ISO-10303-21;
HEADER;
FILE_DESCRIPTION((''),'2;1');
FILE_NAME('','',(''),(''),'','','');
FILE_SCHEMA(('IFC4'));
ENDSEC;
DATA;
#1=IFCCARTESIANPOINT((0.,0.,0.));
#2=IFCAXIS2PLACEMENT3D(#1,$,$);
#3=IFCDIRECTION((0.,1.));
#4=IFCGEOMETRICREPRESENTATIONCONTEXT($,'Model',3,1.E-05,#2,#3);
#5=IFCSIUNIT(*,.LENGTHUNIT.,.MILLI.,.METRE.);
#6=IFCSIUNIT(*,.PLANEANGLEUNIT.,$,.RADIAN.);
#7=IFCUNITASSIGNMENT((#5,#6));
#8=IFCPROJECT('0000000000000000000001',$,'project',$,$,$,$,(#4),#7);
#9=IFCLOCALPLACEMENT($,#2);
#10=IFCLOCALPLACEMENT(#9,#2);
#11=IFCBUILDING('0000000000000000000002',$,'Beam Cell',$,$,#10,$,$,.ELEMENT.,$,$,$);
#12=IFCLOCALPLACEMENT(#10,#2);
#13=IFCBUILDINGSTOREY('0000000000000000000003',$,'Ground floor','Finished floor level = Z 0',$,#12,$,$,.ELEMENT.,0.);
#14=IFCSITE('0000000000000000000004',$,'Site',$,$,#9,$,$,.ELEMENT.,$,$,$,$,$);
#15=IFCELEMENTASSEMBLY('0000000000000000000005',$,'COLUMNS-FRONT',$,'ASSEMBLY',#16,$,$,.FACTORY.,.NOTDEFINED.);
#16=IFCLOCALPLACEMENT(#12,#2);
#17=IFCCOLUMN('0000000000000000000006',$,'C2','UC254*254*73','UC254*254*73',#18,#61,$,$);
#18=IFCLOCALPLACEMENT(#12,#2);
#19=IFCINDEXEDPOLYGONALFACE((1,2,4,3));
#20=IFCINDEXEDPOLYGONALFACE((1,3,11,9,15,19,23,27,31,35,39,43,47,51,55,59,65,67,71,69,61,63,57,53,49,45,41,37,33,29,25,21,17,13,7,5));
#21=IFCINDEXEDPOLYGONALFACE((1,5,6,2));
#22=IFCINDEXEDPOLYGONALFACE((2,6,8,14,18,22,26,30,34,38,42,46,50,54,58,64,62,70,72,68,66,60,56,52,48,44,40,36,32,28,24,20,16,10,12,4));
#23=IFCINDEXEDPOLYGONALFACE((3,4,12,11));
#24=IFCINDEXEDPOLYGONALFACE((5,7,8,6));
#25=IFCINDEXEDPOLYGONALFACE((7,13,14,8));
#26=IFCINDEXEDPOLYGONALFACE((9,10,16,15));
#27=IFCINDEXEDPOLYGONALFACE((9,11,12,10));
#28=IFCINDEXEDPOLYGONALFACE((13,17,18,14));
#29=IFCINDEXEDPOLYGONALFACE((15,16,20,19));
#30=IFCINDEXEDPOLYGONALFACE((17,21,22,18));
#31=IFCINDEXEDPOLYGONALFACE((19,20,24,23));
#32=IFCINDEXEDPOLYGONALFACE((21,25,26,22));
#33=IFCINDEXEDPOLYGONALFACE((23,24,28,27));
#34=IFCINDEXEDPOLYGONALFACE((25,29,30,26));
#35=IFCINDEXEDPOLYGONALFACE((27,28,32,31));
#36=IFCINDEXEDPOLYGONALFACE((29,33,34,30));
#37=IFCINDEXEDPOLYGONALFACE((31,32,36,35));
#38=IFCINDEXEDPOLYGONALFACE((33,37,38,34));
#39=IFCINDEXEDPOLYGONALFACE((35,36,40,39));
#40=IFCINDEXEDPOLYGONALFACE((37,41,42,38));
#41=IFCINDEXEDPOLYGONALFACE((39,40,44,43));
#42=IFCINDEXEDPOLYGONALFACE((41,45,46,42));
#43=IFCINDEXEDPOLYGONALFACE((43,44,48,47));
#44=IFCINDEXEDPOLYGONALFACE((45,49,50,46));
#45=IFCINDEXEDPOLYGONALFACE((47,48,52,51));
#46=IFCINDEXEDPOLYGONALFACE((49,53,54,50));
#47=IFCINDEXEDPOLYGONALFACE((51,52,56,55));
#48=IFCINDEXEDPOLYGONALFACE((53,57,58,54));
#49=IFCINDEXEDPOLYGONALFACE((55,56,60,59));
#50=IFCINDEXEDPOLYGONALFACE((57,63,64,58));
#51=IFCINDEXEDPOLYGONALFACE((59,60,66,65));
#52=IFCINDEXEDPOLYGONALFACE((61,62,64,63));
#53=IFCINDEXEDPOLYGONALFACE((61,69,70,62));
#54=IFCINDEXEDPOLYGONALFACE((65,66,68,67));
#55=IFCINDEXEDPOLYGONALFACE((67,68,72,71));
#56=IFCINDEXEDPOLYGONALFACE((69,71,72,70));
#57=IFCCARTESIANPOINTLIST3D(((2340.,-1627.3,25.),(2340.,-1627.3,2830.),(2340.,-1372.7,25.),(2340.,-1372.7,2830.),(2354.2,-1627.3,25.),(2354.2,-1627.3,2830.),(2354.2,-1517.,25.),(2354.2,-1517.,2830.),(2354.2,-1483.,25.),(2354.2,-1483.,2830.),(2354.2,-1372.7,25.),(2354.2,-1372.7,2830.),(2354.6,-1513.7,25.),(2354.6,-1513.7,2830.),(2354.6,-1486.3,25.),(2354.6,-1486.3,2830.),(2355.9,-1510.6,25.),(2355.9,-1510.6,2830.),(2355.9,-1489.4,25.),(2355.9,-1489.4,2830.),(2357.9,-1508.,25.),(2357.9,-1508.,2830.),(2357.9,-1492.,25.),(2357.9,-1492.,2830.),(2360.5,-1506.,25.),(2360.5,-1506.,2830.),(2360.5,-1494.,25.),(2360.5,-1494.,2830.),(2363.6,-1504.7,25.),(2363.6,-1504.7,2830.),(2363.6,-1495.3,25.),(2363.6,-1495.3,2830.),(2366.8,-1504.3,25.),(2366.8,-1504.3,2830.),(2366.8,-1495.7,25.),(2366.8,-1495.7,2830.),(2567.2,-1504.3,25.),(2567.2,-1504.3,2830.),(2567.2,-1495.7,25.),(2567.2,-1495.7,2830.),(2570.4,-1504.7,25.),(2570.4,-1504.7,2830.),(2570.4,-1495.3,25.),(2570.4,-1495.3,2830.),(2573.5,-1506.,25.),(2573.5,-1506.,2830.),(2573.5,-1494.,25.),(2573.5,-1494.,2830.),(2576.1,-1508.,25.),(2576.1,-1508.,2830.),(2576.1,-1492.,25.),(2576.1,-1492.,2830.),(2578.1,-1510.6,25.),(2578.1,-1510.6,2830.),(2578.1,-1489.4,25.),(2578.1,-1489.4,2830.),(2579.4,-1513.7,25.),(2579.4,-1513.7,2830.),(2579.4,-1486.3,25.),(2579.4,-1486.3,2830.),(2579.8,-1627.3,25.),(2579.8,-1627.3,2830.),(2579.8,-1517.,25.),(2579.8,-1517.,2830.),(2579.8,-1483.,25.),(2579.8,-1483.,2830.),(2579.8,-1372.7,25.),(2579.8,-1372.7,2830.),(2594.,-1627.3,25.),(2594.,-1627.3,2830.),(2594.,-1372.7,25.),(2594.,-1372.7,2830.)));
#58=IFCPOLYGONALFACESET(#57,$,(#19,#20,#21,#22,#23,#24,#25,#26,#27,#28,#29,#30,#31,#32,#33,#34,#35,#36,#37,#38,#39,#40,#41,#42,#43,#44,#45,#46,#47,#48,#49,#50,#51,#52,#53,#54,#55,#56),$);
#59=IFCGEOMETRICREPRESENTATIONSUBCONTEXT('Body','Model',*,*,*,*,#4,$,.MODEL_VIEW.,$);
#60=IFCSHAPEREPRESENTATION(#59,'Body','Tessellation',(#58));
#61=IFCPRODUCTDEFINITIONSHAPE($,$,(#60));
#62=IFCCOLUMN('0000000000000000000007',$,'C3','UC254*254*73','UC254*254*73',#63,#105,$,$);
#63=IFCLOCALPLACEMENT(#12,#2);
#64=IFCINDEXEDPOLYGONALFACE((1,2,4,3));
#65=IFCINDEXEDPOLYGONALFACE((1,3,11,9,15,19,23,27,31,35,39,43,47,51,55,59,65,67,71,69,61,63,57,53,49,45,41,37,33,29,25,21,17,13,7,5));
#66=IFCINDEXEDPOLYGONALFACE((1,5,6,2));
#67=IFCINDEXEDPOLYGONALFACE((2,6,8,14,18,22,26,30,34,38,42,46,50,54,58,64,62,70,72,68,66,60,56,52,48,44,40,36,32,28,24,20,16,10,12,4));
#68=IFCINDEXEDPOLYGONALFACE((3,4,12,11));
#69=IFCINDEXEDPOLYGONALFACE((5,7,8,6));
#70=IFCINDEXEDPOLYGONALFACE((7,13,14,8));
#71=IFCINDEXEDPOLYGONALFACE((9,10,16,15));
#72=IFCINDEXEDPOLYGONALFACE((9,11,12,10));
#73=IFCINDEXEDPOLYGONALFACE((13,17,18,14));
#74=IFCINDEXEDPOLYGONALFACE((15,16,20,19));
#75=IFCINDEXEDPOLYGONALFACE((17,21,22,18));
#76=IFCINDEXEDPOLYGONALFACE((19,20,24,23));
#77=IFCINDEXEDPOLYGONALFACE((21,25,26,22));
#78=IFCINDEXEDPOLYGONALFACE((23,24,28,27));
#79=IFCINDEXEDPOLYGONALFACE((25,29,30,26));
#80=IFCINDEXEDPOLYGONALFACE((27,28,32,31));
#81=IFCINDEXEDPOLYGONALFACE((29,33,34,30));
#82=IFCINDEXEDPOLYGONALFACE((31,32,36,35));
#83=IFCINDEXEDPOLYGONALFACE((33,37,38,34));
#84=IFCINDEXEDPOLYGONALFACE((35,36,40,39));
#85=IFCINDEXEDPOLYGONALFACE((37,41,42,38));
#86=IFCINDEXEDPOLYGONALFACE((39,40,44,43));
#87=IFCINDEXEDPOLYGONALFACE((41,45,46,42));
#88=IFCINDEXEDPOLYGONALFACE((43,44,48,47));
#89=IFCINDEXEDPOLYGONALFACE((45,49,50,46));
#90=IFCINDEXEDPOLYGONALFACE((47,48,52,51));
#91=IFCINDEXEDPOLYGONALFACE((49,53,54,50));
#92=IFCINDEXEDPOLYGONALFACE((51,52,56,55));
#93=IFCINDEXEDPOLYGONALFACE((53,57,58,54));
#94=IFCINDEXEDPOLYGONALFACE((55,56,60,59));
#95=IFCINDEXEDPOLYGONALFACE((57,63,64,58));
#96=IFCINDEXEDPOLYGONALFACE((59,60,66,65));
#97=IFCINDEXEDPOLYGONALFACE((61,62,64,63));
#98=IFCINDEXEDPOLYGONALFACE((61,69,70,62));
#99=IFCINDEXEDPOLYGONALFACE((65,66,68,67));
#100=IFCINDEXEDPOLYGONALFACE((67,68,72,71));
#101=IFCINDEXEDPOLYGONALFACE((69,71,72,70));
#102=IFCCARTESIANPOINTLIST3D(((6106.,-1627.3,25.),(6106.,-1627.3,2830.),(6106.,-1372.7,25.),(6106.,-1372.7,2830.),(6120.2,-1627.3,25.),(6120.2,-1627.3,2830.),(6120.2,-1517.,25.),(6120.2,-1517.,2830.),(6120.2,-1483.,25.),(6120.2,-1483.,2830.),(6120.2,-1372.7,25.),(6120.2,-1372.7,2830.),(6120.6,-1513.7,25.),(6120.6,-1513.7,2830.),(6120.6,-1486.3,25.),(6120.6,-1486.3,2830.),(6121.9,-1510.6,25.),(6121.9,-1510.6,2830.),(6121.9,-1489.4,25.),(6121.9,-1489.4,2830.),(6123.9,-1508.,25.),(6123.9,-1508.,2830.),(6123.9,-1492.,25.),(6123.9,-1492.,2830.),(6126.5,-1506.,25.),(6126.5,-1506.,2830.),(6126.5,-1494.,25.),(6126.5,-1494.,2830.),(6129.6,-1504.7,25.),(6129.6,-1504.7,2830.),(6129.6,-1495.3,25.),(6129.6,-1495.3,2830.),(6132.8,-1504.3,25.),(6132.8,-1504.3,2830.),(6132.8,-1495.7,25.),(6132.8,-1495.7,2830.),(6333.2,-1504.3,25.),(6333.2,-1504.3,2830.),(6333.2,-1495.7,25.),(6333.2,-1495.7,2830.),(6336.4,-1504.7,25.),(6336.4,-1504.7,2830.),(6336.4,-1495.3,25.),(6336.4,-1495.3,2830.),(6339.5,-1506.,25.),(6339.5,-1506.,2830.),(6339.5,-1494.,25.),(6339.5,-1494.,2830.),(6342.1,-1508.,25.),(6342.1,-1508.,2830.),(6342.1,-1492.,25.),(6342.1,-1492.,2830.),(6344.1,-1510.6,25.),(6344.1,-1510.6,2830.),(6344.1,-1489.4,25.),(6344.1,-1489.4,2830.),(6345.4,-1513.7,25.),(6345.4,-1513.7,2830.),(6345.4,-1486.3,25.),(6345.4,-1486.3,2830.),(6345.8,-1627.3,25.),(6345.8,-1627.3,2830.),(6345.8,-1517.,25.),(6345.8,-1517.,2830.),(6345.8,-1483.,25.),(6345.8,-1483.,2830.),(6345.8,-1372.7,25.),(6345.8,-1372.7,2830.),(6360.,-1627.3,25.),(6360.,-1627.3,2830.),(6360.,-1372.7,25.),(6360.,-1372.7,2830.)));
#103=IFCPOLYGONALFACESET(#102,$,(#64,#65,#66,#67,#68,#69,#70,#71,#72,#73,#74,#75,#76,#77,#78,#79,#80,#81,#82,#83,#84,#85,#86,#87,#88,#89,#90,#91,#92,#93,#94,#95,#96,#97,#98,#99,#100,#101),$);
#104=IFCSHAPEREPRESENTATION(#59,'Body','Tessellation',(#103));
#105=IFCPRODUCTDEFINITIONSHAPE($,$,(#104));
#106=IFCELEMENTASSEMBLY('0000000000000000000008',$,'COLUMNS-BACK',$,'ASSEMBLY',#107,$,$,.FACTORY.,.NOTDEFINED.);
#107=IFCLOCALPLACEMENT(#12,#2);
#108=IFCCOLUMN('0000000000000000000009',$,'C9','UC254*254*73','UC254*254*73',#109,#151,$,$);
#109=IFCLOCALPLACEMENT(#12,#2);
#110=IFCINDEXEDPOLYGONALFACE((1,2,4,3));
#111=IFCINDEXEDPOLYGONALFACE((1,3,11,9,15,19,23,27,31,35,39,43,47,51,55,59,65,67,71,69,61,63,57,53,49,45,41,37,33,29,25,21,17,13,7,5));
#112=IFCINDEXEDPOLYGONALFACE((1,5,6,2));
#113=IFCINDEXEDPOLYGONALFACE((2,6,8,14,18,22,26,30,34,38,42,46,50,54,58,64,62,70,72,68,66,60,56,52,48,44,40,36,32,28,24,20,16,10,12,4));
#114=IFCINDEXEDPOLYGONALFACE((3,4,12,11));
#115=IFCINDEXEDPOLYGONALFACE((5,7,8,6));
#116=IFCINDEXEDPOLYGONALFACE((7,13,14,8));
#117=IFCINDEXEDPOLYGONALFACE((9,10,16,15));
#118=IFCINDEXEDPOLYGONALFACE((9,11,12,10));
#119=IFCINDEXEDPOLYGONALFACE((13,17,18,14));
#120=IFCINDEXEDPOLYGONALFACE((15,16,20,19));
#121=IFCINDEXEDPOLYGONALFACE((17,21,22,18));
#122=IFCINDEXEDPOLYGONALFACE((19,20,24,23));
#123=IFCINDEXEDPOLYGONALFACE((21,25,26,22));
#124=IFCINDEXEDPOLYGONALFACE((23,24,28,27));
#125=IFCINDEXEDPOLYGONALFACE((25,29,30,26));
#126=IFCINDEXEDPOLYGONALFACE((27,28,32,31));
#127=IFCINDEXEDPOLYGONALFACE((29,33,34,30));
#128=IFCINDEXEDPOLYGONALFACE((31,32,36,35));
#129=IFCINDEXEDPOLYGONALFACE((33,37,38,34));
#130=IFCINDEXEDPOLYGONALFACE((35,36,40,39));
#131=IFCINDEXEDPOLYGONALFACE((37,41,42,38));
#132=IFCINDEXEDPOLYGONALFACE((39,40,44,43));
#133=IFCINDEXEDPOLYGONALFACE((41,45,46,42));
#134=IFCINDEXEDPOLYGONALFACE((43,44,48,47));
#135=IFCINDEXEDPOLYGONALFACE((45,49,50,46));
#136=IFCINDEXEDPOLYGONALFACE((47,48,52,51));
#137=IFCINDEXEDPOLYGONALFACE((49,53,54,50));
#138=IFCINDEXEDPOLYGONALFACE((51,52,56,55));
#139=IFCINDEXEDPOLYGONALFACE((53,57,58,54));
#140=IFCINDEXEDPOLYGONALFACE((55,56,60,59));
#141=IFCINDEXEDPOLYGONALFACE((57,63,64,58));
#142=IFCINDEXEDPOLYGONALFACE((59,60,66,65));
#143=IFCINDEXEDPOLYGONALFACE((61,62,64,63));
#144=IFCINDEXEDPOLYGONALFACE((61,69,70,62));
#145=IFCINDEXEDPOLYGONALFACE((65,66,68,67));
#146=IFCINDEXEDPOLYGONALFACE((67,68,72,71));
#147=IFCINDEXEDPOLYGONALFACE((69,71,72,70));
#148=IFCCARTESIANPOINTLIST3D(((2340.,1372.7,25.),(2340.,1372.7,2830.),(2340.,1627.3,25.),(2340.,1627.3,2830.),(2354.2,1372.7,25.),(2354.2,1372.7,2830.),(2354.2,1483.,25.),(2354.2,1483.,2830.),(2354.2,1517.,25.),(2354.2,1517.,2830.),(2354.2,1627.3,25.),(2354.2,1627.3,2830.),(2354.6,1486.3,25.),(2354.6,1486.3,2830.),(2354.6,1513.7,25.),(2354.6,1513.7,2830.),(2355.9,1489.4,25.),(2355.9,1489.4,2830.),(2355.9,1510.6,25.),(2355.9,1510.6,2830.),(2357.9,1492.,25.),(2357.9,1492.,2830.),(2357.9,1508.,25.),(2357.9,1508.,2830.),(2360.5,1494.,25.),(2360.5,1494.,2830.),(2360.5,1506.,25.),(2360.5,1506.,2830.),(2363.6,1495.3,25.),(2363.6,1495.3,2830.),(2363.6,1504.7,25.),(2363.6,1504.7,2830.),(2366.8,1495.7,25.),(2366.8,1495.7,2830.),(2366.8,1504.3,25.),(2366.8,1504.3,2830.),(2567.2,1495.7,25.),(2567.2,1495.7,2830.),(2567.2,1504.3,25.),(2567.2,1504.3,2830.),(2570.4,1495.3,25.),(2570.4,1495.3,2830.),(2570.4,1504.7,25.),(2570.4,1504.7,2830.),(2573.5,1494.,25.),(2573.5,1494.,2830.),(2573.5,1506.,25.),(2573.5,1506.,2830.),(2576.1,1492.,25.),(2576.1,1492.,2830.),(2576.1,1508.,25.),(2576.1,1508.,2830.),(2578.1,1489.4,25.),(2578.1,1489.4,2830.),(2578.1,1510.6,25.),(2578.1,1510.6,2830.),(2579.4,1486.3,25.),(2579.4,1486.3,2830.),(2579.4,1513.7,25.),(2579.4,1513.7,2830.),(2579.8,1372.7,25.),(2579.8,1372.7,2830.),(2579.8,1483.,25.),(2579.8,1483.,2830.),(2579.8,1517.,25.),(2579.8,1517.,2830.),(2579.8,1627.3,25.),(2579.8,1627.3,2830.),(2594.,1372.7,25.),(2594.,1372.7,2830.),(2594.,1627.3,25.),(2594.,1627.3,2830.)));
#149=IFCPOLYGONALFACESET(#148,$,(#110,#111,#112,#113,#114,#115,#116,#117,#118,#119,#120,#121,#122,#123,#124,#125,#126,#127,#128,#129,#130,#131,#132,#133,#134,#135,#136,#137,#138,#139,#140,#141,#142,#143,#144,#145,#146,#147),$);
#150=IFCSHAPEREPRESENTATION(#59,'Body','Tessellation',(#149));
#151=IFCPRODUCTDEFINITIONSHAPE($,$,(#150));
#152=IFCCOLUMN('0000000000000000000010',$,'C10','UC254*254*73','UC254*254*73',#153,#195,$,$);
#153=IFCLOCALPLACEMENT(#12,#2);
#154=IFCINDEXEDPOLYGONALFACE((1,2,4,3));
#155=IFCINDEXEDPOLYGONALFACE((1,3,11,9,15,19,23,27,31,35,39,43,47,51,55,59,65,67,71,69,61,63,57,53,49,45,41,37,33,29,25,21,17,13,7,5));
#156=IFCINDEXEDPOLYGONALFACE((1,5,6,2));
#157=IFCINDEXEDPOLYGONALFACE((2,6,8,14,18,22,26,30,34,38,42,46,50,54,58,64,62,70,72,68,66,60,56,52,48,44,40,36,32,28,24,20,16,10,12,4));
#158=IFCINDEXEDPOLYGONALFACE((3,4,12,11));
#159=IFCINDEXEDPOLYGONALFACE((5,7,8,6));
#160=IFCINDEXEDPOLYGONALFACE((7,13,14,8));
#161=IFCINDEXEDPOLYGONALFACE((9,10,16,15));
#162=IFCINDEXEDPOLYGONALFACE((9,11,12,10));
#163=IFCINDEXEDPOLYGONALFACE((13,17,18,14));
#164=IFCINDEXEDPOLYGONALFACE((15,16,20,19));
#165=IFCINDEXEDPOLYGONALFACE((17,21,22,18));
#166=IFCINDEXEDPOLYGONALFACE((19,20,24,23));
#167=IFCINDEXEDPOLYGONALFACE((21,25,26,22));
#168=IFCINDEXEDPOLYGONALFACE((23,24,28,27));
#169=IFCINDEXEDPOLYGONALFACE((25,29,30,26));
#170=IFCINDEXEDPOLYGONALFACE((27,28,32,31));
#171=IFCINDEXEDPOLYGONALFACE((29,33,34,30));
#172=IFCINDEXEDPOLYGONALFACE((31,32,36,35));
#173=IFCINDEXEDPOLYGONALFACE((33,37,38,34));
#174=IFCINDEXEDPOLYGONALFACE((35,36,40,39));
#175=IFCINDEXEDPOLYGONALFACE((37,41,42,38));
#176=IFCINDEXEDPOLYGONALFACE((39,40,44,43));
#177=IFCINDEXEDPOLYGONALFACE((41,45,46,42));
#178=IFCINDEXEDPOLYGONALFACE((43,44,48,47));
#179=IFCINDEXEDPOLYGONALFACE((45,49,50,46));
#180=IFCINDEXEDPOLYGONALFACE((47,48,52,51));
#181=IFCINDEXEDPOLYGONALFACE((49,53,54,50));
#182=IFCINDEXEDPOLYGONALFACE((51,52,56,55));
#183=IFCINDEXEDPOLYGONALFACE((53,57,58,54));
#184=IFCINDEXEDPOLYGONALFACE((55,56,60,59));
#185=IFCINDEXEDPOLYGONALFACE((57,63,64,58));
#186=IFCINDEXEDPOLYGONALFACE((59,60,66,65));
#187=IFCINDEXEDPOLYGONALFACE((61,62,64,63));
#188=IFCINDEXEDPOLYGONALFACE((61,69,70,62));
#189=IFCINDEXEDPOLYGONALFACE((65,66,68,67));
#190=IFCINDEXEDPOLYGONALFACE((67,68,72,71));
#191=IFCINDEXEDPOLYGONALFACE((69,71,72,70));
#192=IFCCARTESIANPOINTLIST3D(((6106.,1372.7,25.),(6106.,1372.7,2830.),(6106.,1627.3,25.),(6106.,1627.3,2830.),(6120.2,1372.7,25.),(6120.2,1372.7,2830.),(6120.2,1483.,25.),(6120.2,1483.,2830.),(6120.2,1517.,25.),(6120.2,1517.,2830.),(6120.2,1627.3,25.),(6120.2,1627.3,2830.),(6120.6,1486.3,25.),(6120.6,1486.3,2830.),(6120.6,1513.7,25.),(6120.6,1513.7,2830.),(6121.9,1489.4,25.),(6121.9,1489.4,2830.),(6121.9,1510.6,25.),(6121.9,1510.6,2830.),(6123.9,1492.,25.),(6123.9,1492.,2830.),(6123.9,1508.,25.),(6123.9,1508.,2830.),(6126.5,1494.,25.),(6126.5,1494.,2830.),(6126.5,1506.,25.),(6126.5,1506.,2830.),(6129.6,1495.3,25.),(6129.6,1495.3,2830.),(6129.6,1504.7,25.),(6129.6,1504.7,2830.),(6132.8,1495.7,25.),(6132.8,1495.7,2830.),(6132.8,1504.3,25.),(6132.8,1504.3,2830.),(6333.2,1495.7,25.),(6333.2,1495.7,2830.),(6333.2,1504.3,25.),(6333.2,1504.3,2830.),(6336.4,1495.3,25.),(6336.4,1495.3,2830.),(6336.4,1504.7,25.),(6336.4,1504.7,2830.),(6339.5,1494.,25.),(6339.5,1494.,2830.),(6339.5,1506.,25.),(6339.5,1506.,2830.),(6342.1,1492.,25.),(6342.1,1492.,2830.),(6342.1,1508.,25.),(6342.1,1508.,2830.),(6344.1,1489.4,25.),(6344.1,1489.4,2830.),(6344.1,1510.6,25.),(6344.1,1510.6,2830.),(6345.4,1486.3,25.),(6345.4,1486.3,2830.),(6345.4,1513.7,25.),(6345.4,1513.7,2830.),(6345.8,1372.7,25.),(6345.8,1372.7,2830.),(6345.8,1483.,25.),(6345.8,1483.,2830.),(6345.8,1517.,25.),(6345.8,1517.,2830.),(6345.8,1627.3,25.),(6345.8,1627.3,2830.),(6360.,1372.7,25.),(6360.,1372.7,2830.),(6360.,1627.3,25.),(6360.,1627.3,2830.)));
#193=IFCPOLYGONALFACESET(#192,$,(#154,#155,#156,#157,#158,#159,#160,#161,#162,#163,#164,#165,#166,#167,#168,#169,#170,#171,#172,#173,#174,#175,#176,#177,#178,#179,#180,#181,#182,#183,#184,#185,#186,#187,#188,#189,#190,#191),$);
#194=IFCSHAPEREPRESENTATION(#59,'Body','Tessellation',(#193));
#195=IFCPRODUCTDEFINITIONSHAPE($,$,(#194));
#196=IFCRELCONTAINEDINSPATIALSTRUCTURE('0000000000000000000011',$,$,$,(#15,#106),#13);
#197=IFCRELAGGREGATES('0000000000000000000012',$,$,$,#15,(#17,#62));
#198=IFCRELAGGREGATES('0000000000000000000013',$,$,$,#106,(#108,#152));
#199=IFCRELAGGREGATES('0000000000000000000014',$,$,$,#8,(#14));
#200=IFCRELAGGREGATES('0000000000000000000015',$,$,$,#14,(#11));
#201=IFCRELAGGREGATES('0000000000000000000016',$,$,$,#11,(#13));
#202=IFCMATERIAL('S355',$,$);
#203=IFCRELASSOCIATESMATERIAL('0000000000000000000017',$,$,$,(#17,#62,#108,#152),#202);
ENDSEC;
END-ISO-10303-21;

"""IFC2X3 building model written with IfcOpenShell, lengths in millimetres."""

from ifc_helpers import new_model, si_unit, direction, frame, origin, origin_2d, place, context, subcontext, project, spatial, i_section, extrude, material, element, aggregate, save


model = new_model("IFC2X3")

# Units and contexts
model_context = context("Model", 3, precision=1e-05, world=origin(), true_north=direction((0.0, 1.0)))
body_context = subcontext(model_context, "Body", "Model", "MODEL_VIEW")
ifc_project = project(units=[si_unit("LENGTHUNIT", "METRE", prefix="MILLI"), si_unit("PLANEANGLEUNIT", "RADIAN")], contexts=[model_context])

# Site, building, storey
site_placement = place(None, origin())
site = spatial("IfcSite", under=ifc_project, at=site_placement, Name="Site", CompositionType="ELEMENT")
building_placement = place(site_placement, origin())
building = spatial("IfcBuilding", under=site, at=building_placement, Name="Beam Cell", CompositionType="ELEMENT")
storey_placement = place(building_placement, origin())
storey = spatial("IfcBuildingStorey", under=building, at=storey_placement, Name="Ground floor", Description="Finished floor level = Z 0", CompositionType="ELEMENT", Elevation=0.0)

# Element assemblies, columns
assembly_1_placement = place(storey_placement, origin())
assembly_1 = element("IfcElementAssembly", 1, at=assembly_1_placement, inside=storey, Name="COLUMNS-FRONT", ObjectType="ASSEMBLY", AssemblyPlace="FACTORY", PredefinedType="NOTDEFINED")
ifc_material = material(Name="S355")
column_1_placement = place(storey_placement, frame((2467.0, -1500.0, 25.0), z_axis=(0.0, 0.0, 1.0), x_axis=(0.0, 1.0, 0.0)))
column_1 = element("IfcColumn", 2, at=column_1_placement, material=ifc_material, Name="C2", Description="UC254*254*73", ObjectType="UC254*254*73", context=body_context, shape_type="SweptSolid", body=[
    extrude(i_section(OverallWidth=254.6, OverallDepth=254.1, WebThickness=8.6, FlangeThickness=14.2, FilletRadius=12.7, at=origin_2d()), origin(), (0.0, 0.0, 1.0), 2805.0),
])
column_2_placement = place(storey_placement, frame((6233.0, -1500.0, 25.0), z_axis=(0.0, 0.0, 1.0), x_axis=(0.0, 1.0, 0.0)))
column_2 = element("IfcColumn", 3, at=column_2_placement, material=ifc_material, Name="C3", Description="UC254*254*73", ObjectType="UC254*254*73", context=body_context, shape_type="SweptSolid", body=[
    extrude(i_section(OverallWidth=254.6, OverallDepth=254.1, WebThickness=8.6, FlangeThickness=14.2, FilletRadius=12.7, at=origin_2d()), origin(), (0.0, 0.0, 1.0), 2805.0),
])
assembly_2_placement = place(storey_placement, origin())
assembly_2 = element("IfcElementAssembly", 4, at=assembly_2_placement, inside=storey, Name="COLUMNS-BACK", ObjectType="ASSEMBLY", AssemblyPlace="FACTORY", PredefinedType="NOTDEFINED")
column_3_placement = place(storey_placement, frame((2467.0, 1500.0, 25.0), z_axis=(0.0, 0.0, 1.0), x_axis=(0.0, 1.0, 0.0)))
column_3 = element("IfcColumn", 5, at=column_3_placement, material=ifc_material, Name="C9", Description="UC254*254*73", ObjectType="UC254*254*73", context=body_context, shape_type="SweptSolid", body=[
    extrude(i_section(OverallWidth=254.6, OverallDepth=254.1, WebThickness=8.6, FlangeThickness=14.2, FilletRadius=12.7, at=origin_2d()), origin(), (0.0, 0.0, 1.0), 2805.0),
])
column_4_placement = place(storey_placement, frame((6233.0, 1500.0, 25.0), z_axis=(0.0, 0.0, 1.0), x_axis=(0.0, 1.0, 0.0)))
column_4 = element("IfcColumn", 6, at=column_4_placement, material=ifc_material, Name="C10", Description="UC254*254*73", ObjectType="UC254*254*73", context=body_context, shape_type="SweptSolid", body=[
    extrude(i_section(OverallWidth=254.6, OverallDepth=254.1, WebThickness=8.6, FlangeThickness=14.2, FilletRadius=12.7, at=origin_2d()), origin(), (0.0, 0.0, 1.0), 2805.0),
])

aggregate(assembly_1, [column_1, column_2])
aggregate(assembly_2, [column_3, column_4])

save(model, "model.ifc")
